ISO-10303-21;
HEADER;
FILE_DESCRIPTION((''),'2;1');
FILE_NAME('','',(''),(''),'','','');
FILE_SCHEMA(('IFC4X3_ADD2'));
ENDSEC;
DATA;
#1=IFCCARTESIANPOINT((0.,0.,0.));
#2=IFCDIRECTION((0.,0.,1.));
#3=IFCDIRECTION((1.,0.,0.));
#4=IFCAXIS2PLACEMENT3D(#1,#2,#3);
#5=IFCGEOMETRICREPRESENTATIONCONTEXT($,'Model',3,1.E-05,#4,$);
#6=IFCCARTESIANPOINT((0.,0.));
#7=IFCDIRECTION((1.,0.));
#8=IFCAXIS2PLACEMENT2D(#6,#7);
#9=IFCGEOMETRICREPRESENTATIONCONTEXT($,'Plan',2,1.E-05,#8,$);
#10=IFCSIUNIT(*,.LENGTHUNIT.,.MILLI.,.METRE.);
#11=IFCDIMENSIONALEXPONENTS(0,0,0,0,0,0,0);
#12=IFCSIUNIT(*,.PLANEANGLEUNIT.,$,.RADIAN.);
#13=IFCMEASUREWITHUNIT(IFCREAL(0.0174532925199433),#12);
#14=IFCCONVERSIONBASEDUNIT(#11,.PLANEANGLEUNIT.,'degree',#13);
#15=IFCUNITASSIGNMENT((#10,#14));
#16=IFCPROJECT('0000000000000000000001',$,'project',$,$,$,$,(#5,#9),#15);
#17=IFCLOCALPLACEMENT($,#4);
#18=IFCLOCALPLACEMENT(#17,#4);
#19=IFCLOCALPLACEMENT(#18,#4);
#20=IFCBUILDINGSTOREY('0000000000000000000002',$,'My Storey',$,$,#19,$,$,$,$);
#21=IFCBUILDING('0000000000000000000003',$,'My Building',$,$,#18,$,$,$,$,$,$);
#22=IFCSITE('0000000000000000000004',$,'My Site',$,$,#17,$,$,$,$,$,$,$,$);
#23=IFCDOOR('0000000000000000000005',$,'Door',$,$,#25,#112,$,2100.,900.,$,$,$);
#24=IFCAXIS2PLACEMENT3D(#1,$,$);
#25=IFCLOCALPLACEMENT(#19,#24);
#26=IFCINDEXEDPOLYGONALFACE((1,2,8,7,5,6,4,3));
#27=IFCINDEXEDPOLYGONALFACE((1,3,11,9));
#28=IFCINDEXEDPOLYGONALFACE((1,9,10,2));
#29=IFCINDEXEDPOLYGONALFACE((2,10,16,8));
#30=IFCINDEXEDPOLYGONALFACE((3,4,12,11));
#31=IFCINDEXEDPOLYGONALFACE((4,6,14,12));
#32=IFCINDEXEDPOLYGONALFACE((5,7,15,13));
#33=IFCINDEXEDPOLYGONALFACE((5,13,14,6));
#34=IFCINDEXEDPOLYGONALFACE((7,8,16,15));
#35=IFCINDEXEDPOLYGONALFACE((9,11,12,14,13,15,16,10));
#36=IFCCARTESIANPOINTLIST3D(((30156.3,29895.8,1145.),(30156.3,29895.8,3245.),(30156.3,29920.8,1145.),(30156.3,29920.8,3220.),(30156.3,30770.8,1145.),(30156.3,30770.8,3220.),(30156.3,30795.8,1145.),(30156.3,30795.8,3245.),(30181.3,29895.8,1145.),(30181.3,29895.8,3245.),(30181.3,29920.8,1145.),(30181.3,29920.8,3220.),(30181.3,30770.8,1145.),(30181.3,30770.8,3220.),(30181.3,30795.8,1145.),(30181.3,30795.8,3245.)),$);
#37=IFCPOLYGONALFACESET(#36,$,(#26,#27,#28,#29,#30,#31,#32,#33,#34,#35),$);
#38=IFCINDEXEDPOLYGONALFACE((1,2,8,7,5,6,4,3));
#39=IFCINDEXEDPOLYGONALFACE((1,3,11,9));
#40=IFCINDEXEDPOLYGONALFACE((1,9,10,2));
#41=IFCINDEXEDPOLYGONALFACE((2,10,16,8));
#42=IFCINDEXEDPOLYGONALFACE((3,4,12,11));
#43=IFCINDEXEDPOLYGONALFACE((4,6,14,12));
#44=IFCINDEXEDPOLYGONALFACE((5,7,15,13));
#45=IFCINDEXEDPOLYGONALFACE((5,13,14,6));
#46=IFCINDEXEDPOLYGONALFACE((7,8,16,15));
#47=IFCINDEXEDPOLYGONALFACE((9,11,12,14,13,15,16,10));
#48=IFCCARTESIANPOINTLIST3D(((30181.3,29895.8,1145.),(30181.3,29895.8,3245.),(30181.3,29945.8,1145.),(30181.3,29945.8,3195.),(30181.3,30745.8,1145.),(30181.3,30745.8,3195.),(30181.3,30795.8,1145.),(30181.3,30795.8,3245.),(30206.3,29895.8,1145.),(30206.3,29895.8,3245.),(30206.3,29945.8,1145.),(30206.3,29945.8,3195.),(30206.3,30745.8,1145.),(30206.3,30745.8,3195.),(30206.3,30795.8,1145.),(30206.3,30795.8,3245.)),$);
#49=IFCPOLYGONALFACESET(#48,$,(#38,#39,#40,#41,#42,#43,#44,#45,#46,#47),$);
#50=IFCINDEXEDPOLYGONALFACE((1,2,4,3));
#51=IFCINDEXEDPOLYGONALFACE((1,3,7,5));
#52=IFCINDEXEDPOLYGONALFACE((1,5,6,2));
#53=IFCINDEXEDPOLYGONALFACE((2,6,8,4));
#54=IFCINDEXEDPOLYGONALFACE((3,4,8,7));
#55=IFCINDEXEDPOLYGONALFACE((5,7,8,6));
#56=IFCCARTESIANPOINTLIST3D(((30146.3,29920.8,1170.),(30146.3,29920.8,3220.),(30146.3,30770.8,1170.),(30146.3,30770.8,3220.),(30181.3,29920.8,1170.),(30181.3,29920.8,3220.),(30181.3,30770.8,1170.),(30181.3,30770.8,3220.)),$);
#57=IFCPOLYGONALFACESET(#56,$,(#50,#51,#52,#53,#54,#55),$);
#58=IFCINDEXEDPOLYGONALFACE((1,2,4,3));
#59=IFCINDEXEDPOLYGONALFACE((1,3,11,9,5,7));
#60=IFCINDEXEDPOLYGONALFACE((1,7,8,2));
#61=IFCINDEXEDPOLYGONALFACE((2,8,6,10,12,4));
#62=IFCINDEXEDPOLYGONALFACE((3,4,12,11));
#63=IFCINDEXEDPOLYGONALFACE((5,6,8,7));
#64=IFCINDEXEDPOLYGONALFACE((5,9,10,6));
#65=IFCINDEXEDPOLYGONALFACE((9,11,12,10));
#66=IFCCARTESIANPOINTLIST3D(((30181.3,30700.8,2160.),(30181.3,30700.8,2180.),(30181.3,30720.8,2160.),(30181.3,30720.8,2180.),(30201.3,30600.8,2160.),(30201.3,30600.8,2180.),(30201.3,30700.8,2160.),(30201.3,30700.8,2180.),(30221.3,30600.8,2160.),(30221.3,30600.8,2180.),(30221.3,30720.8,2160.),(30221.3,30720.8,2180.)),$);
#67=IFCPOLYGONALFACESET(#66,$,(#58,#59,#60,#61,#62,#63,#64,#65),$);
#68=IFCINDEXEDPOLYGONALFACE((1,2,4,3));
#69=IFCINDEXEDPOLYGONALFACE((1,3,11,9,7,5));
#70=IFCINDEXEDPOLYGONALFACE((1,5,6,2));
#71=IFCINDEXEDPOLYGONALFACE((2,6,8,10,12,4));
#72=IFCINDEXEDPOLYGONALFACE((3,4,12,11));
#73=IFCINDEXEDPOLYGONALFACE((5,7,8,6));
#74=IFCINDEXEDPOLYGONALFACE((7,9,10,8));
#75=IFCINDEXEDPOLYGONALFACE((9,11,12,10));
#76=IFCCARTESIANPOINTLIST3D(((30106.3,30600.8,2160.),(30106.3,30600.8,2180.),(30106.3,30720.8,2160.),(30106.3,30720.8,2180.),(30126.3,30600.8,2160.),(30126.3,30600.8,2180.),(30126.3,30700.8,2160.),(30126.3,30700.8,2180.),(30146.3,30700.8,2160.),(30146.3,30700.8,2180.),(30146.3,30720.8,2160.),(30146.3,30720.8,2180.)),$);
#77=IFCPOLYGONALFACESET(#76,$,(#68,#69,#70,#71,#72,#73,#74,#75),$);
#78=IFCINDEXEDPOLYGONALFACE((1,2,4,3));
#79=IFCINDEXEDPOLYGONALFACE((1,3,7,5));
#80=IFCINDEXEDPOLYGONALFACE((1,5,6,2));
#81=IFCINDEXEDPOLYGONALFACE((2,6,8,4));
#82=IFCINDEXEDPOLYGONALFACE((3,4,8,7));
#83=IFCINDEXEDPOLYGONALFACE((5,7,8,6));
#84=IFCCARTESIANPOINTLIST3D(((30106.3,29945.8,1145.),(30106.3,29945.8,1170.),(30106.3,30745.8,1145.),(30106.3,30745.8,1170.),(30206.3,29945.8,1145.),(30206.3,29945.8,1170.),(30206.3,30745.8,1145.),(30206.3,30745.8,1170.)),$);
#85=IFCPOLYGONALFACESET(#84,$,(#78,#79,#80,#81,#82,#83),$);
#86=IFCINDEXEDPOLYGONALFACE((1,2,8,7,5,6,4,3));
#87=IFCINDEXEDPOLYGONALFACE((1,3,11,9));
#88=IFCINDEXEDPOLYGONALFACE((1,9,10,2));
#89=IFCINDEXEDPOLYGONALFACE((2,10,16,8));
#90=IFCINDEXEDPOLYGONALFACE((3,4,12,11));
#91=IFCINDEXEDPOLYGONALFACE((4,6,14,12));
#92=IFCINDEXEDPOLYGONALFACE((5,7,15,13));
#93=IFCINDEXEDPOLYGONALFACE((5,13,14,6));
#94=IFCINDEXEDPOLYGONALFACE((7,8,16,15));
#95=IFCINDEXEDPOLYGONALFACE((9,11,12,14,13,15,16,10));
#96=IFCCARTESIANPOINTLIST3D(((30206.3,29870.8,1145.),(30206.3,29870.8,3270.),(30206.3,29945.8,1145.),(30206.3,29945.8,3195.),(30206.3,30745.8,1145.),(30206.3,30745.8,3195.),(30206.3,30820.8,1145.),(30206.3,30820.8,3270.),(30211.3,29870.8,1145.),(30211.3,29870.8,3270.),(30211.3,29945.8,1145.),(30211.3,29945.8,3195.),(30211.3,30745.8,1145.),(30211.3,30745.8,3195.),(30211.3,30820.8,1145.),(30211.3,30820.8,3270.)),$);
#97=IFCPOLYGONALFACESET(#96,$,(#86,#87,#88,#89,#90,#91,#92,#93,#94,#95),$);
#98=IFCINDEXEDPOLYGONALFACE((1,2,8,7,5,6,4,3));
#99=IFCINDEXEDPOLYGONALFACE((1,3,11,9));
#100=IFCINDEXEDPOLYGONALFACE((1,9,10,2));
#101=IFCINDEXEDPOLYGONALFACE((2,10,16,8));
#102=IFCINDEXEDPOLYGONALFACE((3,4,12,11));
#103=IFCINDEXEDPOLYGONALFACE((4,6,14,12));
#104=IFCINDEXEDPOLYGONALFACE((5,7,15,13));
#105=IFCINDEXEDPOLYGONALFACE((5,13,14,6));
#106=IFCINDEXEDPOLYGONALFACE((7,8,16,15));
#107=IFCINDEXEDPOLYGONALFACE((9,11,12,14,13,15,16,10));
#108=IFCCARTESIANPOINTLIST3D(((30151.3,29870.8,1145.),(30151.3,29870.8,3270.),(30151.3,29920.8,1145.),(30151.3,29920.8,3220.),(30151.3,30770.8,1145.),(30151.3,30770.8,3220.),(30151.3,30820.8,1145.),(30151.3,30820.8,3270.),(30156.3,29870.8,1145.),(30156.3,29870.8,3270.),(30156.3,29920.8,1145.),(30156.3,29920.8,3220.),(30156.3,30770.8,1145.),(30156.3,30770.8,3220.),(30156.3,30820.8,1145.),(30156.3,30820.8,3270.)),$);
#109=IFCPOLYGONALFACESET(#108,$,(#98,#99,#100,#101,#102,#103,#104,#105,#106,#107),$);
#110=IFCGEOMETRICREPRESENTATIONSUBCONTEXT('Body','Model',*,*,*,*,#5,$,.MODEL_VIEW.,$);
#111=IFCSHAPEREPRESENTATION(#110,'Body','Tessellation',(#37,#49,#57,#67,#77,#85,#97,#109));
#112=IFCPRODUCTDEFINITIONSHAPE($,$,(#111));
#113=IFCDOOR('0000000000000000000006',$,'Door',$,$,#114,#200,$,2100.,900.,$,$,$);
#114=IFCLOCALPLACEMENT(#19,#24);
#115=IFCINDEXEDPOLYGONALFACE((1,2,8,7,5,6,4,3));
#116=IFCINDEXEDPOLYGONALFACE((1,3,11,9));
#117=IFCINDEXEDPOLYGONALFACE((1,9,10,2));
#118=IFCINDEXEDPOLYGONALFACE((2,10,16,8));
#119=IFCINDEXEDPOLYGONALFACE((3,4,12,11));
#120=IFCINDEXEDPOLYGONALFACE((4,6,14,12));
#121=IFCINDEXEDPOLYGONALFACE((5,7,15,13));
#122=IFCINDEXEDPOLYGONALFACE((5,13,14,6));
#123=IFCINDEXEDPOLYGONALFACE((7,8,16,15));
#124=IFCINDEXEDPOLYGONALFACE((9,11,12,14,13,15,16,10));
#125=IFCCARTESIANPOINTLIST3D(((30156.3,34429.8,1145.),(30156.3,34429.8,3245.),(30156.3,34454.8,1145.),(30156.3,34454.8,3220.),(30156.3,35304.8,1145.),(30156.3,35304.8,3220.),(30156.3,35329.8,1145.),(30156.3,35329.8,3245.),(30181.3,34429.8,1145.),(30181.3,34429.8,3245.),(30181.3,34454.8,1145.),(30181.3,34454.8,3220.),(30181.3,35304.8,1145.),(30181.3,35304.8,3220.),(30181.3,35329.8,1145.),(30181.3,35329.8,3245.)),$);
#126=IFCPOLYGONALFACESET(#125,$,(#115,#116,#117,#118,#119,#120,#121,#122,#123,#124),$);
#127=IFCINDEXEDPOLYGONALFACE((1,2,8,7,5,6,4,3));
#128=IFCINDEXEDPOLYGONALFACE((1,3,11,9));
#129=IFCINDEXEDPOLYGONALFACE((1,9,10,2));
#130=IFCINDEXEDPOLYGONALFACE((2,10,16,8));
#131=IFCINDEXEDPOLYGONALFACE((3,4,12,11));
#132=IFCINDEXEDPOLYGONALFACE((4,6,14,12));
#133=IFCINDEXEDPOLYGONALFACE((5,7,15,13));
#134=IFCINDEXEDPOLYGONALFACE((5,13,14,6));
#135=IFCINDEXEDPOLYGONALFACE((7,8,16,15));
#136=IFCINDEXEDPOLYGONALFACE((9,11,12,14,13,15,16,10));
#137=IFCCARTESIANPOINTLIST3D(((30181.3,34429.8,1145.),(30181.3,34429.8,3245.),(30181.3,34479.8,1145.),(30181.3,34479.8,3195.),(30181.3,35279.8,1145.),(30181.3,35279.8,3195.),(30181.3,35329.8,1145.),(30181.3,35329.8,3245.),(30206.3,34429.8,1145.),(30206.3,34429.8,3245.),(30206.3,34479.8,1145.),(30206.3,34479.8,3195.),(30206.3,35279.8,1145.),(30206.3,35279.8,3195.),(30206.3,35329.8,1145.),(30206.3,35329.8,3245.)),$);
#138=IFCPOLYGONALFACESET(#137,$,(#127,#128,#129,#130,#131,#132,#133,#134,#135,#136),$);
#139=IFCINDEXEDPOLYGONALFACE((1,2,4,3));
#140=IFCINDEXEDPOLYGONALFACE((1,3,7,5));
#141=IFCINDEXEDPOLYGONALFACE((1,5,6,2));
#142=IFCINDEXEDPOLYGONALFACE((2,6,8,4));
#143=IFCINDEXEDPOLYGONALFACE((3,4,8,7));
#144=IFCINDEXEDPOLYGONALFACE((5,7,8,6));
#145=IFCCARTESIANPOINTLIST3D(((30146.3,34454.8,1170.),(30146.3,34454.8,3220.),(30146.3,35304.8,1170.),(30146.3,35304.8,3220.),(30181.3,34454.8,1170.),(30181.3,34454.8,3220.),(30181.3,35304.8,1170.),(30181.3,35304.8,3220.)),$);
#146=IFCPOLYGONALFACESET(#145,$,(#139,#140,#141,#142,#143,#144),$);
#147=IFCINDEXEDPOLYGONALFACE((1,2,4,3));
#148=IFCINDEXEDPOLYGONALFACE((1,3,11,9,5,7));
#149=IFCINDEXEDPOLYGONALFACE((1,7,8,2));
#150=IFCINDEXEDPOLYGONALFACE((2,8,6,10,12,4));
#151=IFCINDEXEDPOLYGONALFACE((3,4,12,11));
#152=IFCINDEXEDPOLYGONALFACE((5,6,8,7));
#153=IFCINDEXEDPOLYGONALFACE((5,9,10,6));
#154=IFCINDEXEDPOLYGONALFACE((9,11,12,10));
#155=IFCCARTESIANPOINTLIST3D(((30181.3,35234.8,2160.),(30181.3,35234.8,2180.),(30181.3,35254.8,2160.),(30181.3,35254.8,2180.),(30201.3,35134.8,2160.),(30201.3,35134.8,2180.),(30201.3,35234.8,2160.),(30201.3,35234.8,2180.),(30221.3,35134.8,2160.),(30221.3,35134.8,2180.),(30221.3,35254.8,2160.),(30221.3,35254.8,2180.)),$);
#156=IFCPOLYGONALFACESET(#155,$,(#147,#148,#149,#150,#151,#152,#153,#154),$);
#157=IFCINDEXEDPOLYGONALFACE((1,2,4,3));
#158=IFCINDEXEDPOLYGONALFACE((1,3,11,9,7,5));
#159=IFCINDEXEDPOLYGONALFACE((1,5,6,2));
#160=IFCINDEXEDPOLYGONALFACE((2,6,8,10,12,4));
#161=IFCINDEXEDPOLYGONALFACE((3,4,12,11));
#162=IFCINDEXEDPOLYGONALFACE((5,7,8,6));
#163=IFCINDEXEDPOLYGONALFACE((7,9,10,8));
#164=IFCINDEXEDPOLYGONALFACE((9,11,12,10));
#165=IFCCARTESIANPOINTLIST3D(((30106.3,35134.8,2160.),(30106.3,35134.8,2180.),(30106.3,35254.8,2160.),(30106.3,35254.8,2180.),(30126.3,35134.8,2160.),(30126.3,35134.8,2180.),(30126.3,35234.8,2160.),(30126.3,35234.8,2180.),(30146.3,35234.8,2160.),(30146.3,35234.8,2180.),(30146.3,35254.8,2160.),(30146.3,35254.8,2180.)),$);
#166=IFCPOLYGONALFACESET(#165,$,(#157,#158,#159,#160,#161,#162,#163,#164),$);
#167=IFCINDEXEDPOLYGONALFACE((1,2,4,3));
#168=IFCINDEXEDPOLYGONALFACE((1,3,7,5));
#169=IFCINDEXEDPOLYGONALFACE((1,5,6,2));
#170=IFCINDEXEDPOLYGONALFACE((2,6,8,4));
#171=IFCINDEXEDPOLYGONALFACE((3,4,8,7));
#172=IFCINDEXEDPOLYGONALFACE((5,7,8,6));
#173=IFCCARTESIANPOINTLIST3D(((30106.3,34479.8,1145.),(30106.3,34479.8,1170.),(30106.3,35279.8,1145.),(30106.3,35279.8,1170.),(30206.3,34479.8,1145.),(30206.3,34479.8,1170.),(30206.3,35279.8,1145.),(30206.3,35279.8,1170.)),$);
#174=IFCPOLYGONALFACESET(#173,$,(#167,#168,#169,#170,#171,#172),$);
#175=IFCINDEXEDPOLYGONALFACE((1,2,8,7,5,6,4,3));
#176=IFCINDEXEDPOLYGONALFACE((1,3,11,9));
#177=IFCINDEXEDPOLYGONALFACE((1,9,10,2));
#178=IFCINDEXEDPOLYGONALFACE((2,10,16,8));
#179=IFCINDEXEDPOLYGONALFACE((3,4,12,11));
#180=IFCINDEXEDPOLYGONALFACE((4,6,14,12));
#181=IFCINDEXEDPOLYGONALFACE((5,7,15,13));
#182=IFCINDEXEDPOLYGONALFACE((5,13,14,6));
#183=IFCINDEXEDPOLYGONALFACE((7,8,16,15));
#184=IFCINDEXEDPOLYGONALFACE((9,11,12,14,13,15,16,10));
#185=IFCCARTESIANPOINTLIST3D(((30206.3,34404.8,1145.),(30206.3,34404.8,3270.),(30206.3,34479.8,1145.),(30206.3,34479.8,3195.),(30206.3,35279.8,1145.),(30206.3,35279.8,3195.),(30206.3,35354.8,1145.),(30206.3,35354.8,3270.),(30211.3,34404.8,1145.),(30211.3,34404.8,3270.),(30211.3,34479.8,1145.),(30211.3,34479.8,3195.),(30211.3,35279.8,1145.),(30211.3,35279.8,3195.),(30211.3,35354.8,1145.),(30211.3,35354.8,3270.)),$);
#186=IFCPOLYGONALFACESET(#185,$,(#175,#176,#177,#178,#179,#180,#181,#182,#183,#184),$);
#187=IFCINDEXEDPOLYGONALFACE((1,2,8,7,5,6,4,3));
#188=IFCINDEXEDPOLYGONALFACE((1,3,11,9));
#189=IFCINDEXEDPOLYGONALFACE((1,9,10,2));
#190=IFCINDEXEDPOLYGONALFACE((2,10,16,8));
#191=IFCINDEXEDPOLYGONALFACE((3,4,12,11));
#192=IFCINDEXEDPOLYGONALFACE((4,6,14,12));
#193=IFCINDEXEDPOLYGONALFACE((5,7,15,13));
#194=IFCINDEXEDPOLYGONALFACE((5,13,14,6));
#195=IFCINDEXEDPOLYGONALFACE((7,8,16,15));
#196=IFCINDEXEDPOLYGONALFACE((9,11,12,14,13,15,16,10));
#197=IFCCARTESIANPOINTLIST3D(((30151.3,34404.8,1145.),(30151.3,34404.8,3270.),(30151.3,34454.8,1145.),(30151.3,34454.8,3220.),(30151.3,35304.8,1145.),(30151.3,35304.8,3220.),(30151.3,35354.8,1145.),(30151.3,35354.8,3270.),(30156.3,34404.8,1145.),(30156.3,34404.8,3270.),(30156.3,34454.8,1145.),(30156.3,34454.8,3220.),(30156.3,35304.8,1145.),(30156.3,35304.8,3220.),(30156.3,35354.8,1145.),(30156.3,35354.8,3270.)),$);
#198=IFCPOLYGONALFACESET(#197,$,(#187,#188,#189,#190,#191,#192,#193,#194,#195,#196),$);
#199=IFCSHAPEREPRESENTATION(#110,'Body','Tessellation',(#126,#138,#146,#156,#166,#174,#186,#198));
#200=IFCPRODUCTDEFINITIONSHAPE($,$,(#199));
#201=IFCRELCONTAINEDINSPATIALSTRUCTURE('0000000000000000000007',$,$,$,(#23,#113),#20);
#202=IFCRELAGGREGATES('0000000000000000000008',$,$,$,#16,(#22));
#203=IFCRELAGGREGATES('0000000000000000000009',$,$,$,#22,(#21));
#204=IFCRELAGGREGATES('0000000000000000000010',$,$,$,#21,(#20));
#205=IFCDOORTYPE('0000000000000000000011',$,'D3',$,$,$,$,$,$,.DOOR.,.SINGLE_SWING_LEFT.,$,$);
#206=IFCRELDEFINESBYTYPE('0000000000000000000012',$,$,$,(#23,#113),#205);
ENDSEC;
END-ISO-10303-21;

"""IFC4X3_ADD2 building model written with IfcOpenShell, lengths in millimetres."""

from ifc_helpers import new_model, entity, si_unit, converted_unit, frame, origin_with_axes, origin_2d_with_axis, place, context, subcontext, project, spatial, line, indexed_curve, outline, extrude, shape, source, transform, mapped, type_object, type_shapes, element, save


model = new_model("IFC4X3_ADD2")

# Units and contexts
model_context = context("Model", 3, precision=1e-05, world=origin_with_axes())
plan_context = context("Plan", 2, precision=1e-05, world=origin_2d_with_axis())
body_context_1 = subcontext(model_context, "Body", "Model", "MODEL_VIEW")
body_context_2 = subcontext(plan_context, "Body", "Plan", "PLAN_VIEW")
ifc_project = project(units=[si_unit("LENGTHUNIT", "METRE", prefix="MILLI"), converted_unit("PLANEANGLEUNIT", "degree", entity("IfcReal", 0.0174532925199433), si_unit("PLANEANGLEUNIT", "RADIAN"), dimensions=[0, 0, 0, 0, 0, 0, 0])], contexts=[model_context, plan_context])

# Site, building, storey
site_placement = place(None, origin_with_axes())
site = spatial("IfcSite", under=ifc_project, at=site_placement, Name="My Site")
building_placement = place(site_placement, origin_with_axes())
building = spatial("IfcBuilding", under=site, at=building_placement, Name="My Building")
storey_placement = place(building_placement, origin_with_axes())
storey = spatial("IfcBuildingStorey", under=building, at=storey_placement, Name="My Storey")

# Doors
door_type = type_object("IfcDoorType", Name="D3", OperationType="SINGLE_SWING_LEFT", PredefinedType="DOOR")
shared_shape_1 = source(origin_with_axes(), body_context_1, "Body", "SweptSolid", [
    extrude(outline(indexed_curve([(0.0, 0.0), (0.0, 2100.0), (900.0, 2100.0), (900.0, 0.0), (875.0, 0.0), (875.0, 2075.0), (25.0, 2075.0), (25.0, 0.0)], segments=[line(1, 2, 3, 4, 5, 6, 7, 8, 1)])), frame((0.0, 25.0, 0.0), z_axis=(0.0, -1.0, 0.0), x_axis=(1.0, 0.0, 0.0)), (0.0, 0.0, -1.0), 25.0),
    extrude(outline(indexed_curve([(0.0, 0.0), (0.0, 2100.0), (900.0, 2100.0), (900.0, 0.0), (850.0, 0.0), (850.0, 2050.0), (50.0, 2050.0), (50.0, 0.0)], segments=[line(1, 2, 3, 4, 5, 6, 7, 8, 1)])), frame((0.0, 0.0, 0.0), z_axis=(0.0, -1.0, 0.0), x_axis=(1.0, 0.0, 0.0)), (0.0, 0.0, -1.0), 25.0),
    extrude(outline(indexed_curve([(0.0, 0.0), (850.0, 0.0), (850.0, 35.0), (0.0, 35.0)], segments=[line(1, 2, 3, 4, 1)])), frame((25.0, 25.0, 25.0), z_axis=(0.0, 0.0, 1.0), x_axis=(1.0, 0.0, 0.0)), (0.0, 0.0, 1.0), 2050.0),
    extrude(outline(indexed_curve([(0.0, 0.0), (0.0, -40.0), (-120.0, -40.0), (-120.0, -20.0), (-20.0, -20.0), (-20.0, 0.0)], segments=[line(1, 2, 3, 4, 5, 6, 1)])), frame((825.0, 25.0, 1015.0), z_axis=(0.0, 0.0, 1.0), x_axis=(1.0, 0.0, 0.0)), (0.0, 0.0, 1.0), 20.0),
    extrude(outline(indexed_curve([(0.0, 0.0), (0.0, 40.0), (-120.0, 40.0), (-120.0, 20.0), (-20.0, 20.0), (-20.0, 0.0)], segments=[line(1, 2, 3, 4, 5, 6, 1)])), frame((825.0, 60.0, 1015.0), z_axis=(0.0, 0.0, 1.0), x_axis=(1.0, 0.0, 0.0)), (0.0, 0.0, 1.0), 20.0),
    extrude(outline(indexed_curve([(0.0, 0.0), (800.0, 0.0), (800.0, 100.0), (0.0, 100.0)], segments=[line(1, 2, 3, 4, 1)])), frame((50.0, 0.0, 0.0), z_axis=(0.0, 0.0, 1.0), x_axis=(1.0, 0.0, 0.0)), (0.0, 0.0, 1.0), 25.0),
    extrude(outline(indexed_curve([(0.0, 0.0), (0.0, 2125.0), (950.0, 2125.0), (950.0, 0.0), (875.0, 0.0), (875.0, 2050.0), (75.0, 2050.0), (75.0, 0.0)], segments=[line(1, 2, 3, 4, 5, 6, 7, 8, 1)])), frame((-25.0, -5.0, 0.0), z_axis=(0.0, -1.0, 0.0), x_axis=(1.0, 0.0, 0.0)), (0.0, 0.0, -1.0), 5.0),
    extrude(outline(indexed_curve([(0.0, 0.0), (0.0, 2125.0), (950.0, 2125.0), (950.0, 0.0), (900.0, 0.0), (900.0, 2075.0), (50.0, 2075.0), (50.0, 0.0)], segments=[line(1, 2, 3, 4, 5, 6, 7, 8, 1)])), frame((-25.0, 50.0, 0.0), z_axis=(0.0, -1.0, 0.0), x_axis=(1.0, 0.0, 0.0)), (0.0, 0.0, -1.0), 5.0),
])
shared_shape_2 = source(origin_with_axes(), body_context_2, "Body", "Curve2D", [
    entity("IfcIndexedPolyCurve", entity("IfcCartesianPointList2D", [[0.0, 0.0], [0.0, 50.0], [25.0, 50.0], [25.0, 25.0], [50.0, 25.0], [50.0, 0.0]]), [entity("IfcLineIndex", [1, 2, 3, 4, 5, 6, 1])]),
    entity("IfcIndexedPolyCurve", entity("IfcCartesianPointList2D", [[900.0, 0.0], [900.0, 50.0], [875.0, 50.0], [875.0, 25.0], [850.0, 25.0], [850.0, 0.0]]), [entity("IfcLineIndex", [1, 2, 3, 4, 5, 6, 1])]),
    entity("IfcTrimmedCurve", entity("IfcEllipse", entity("IfcAxis2Placement2D", entity("IfcCartesianPoint", [60.0, 50.0]), entity("IfcDirection", [1.0, 0.0])), 815.0, 850.0), [entity("IfcCartesianPoint", [875.0, 50.0])], [entity("IfcCartesianPoint", [60.0, 900.0])], True, "CARTESIAN"),
    entity("IfcIndexedPolyCurve", entity("IfcCartesianPointList2D", [[25.0, 50.0], [60.0, 50.0], [60.0, 900.0], [25.0, 900.0]]), [entity("IfcLineIndex", [1, 2, 3, 4, 1])]),
])
type_shapes(door_type, [shared_shape_1, shared_shape_2])
for number, where, z_axis, x_axis, name in (
    (1, (30206.3, 29895.8, 1145.0), (0.0, 0.0, 1.0), (0.0, 1.0, 0.0), "Door"),
    (2, (30206.3, 34429.8, 1145.0), (0.0, 0.0, 1.0), (0.0, 1.0, 0.0), "Door"),
):
    element("IfcDoor", number, at=place(storey_placement, frame(where, z_axis=z_axis, x_axis=x_axis)), inside=storey, type_object=door_type, Name=name, OverallHeight=2100.0, OverallWidth=900.0, shapes=[
        shape(body_context_1, "Body", "MappedRepresentation", [mapped(shared_shape_1, transform((0.0, 0.0, 0.0), x_axis=(1.0, 0.0, 0.0), y_axis=(0.0, 1.0, 0.0), z_axis=(0.0, 0.0, 1.0), scale=1.0))]),
        shape(body_context_2, "Body", "MappedRepresentation", [mapped(shared_shape_2, transform((0.0, 0.0, 0.0), x_axis=(1.0, 0.0, 0.0), y_axis=(0.0, 1.0, 0.0), z_axis=(0.0, 0.0, 1.0), scale=1.0))]),
    ])

save(model, "model.ifc")
